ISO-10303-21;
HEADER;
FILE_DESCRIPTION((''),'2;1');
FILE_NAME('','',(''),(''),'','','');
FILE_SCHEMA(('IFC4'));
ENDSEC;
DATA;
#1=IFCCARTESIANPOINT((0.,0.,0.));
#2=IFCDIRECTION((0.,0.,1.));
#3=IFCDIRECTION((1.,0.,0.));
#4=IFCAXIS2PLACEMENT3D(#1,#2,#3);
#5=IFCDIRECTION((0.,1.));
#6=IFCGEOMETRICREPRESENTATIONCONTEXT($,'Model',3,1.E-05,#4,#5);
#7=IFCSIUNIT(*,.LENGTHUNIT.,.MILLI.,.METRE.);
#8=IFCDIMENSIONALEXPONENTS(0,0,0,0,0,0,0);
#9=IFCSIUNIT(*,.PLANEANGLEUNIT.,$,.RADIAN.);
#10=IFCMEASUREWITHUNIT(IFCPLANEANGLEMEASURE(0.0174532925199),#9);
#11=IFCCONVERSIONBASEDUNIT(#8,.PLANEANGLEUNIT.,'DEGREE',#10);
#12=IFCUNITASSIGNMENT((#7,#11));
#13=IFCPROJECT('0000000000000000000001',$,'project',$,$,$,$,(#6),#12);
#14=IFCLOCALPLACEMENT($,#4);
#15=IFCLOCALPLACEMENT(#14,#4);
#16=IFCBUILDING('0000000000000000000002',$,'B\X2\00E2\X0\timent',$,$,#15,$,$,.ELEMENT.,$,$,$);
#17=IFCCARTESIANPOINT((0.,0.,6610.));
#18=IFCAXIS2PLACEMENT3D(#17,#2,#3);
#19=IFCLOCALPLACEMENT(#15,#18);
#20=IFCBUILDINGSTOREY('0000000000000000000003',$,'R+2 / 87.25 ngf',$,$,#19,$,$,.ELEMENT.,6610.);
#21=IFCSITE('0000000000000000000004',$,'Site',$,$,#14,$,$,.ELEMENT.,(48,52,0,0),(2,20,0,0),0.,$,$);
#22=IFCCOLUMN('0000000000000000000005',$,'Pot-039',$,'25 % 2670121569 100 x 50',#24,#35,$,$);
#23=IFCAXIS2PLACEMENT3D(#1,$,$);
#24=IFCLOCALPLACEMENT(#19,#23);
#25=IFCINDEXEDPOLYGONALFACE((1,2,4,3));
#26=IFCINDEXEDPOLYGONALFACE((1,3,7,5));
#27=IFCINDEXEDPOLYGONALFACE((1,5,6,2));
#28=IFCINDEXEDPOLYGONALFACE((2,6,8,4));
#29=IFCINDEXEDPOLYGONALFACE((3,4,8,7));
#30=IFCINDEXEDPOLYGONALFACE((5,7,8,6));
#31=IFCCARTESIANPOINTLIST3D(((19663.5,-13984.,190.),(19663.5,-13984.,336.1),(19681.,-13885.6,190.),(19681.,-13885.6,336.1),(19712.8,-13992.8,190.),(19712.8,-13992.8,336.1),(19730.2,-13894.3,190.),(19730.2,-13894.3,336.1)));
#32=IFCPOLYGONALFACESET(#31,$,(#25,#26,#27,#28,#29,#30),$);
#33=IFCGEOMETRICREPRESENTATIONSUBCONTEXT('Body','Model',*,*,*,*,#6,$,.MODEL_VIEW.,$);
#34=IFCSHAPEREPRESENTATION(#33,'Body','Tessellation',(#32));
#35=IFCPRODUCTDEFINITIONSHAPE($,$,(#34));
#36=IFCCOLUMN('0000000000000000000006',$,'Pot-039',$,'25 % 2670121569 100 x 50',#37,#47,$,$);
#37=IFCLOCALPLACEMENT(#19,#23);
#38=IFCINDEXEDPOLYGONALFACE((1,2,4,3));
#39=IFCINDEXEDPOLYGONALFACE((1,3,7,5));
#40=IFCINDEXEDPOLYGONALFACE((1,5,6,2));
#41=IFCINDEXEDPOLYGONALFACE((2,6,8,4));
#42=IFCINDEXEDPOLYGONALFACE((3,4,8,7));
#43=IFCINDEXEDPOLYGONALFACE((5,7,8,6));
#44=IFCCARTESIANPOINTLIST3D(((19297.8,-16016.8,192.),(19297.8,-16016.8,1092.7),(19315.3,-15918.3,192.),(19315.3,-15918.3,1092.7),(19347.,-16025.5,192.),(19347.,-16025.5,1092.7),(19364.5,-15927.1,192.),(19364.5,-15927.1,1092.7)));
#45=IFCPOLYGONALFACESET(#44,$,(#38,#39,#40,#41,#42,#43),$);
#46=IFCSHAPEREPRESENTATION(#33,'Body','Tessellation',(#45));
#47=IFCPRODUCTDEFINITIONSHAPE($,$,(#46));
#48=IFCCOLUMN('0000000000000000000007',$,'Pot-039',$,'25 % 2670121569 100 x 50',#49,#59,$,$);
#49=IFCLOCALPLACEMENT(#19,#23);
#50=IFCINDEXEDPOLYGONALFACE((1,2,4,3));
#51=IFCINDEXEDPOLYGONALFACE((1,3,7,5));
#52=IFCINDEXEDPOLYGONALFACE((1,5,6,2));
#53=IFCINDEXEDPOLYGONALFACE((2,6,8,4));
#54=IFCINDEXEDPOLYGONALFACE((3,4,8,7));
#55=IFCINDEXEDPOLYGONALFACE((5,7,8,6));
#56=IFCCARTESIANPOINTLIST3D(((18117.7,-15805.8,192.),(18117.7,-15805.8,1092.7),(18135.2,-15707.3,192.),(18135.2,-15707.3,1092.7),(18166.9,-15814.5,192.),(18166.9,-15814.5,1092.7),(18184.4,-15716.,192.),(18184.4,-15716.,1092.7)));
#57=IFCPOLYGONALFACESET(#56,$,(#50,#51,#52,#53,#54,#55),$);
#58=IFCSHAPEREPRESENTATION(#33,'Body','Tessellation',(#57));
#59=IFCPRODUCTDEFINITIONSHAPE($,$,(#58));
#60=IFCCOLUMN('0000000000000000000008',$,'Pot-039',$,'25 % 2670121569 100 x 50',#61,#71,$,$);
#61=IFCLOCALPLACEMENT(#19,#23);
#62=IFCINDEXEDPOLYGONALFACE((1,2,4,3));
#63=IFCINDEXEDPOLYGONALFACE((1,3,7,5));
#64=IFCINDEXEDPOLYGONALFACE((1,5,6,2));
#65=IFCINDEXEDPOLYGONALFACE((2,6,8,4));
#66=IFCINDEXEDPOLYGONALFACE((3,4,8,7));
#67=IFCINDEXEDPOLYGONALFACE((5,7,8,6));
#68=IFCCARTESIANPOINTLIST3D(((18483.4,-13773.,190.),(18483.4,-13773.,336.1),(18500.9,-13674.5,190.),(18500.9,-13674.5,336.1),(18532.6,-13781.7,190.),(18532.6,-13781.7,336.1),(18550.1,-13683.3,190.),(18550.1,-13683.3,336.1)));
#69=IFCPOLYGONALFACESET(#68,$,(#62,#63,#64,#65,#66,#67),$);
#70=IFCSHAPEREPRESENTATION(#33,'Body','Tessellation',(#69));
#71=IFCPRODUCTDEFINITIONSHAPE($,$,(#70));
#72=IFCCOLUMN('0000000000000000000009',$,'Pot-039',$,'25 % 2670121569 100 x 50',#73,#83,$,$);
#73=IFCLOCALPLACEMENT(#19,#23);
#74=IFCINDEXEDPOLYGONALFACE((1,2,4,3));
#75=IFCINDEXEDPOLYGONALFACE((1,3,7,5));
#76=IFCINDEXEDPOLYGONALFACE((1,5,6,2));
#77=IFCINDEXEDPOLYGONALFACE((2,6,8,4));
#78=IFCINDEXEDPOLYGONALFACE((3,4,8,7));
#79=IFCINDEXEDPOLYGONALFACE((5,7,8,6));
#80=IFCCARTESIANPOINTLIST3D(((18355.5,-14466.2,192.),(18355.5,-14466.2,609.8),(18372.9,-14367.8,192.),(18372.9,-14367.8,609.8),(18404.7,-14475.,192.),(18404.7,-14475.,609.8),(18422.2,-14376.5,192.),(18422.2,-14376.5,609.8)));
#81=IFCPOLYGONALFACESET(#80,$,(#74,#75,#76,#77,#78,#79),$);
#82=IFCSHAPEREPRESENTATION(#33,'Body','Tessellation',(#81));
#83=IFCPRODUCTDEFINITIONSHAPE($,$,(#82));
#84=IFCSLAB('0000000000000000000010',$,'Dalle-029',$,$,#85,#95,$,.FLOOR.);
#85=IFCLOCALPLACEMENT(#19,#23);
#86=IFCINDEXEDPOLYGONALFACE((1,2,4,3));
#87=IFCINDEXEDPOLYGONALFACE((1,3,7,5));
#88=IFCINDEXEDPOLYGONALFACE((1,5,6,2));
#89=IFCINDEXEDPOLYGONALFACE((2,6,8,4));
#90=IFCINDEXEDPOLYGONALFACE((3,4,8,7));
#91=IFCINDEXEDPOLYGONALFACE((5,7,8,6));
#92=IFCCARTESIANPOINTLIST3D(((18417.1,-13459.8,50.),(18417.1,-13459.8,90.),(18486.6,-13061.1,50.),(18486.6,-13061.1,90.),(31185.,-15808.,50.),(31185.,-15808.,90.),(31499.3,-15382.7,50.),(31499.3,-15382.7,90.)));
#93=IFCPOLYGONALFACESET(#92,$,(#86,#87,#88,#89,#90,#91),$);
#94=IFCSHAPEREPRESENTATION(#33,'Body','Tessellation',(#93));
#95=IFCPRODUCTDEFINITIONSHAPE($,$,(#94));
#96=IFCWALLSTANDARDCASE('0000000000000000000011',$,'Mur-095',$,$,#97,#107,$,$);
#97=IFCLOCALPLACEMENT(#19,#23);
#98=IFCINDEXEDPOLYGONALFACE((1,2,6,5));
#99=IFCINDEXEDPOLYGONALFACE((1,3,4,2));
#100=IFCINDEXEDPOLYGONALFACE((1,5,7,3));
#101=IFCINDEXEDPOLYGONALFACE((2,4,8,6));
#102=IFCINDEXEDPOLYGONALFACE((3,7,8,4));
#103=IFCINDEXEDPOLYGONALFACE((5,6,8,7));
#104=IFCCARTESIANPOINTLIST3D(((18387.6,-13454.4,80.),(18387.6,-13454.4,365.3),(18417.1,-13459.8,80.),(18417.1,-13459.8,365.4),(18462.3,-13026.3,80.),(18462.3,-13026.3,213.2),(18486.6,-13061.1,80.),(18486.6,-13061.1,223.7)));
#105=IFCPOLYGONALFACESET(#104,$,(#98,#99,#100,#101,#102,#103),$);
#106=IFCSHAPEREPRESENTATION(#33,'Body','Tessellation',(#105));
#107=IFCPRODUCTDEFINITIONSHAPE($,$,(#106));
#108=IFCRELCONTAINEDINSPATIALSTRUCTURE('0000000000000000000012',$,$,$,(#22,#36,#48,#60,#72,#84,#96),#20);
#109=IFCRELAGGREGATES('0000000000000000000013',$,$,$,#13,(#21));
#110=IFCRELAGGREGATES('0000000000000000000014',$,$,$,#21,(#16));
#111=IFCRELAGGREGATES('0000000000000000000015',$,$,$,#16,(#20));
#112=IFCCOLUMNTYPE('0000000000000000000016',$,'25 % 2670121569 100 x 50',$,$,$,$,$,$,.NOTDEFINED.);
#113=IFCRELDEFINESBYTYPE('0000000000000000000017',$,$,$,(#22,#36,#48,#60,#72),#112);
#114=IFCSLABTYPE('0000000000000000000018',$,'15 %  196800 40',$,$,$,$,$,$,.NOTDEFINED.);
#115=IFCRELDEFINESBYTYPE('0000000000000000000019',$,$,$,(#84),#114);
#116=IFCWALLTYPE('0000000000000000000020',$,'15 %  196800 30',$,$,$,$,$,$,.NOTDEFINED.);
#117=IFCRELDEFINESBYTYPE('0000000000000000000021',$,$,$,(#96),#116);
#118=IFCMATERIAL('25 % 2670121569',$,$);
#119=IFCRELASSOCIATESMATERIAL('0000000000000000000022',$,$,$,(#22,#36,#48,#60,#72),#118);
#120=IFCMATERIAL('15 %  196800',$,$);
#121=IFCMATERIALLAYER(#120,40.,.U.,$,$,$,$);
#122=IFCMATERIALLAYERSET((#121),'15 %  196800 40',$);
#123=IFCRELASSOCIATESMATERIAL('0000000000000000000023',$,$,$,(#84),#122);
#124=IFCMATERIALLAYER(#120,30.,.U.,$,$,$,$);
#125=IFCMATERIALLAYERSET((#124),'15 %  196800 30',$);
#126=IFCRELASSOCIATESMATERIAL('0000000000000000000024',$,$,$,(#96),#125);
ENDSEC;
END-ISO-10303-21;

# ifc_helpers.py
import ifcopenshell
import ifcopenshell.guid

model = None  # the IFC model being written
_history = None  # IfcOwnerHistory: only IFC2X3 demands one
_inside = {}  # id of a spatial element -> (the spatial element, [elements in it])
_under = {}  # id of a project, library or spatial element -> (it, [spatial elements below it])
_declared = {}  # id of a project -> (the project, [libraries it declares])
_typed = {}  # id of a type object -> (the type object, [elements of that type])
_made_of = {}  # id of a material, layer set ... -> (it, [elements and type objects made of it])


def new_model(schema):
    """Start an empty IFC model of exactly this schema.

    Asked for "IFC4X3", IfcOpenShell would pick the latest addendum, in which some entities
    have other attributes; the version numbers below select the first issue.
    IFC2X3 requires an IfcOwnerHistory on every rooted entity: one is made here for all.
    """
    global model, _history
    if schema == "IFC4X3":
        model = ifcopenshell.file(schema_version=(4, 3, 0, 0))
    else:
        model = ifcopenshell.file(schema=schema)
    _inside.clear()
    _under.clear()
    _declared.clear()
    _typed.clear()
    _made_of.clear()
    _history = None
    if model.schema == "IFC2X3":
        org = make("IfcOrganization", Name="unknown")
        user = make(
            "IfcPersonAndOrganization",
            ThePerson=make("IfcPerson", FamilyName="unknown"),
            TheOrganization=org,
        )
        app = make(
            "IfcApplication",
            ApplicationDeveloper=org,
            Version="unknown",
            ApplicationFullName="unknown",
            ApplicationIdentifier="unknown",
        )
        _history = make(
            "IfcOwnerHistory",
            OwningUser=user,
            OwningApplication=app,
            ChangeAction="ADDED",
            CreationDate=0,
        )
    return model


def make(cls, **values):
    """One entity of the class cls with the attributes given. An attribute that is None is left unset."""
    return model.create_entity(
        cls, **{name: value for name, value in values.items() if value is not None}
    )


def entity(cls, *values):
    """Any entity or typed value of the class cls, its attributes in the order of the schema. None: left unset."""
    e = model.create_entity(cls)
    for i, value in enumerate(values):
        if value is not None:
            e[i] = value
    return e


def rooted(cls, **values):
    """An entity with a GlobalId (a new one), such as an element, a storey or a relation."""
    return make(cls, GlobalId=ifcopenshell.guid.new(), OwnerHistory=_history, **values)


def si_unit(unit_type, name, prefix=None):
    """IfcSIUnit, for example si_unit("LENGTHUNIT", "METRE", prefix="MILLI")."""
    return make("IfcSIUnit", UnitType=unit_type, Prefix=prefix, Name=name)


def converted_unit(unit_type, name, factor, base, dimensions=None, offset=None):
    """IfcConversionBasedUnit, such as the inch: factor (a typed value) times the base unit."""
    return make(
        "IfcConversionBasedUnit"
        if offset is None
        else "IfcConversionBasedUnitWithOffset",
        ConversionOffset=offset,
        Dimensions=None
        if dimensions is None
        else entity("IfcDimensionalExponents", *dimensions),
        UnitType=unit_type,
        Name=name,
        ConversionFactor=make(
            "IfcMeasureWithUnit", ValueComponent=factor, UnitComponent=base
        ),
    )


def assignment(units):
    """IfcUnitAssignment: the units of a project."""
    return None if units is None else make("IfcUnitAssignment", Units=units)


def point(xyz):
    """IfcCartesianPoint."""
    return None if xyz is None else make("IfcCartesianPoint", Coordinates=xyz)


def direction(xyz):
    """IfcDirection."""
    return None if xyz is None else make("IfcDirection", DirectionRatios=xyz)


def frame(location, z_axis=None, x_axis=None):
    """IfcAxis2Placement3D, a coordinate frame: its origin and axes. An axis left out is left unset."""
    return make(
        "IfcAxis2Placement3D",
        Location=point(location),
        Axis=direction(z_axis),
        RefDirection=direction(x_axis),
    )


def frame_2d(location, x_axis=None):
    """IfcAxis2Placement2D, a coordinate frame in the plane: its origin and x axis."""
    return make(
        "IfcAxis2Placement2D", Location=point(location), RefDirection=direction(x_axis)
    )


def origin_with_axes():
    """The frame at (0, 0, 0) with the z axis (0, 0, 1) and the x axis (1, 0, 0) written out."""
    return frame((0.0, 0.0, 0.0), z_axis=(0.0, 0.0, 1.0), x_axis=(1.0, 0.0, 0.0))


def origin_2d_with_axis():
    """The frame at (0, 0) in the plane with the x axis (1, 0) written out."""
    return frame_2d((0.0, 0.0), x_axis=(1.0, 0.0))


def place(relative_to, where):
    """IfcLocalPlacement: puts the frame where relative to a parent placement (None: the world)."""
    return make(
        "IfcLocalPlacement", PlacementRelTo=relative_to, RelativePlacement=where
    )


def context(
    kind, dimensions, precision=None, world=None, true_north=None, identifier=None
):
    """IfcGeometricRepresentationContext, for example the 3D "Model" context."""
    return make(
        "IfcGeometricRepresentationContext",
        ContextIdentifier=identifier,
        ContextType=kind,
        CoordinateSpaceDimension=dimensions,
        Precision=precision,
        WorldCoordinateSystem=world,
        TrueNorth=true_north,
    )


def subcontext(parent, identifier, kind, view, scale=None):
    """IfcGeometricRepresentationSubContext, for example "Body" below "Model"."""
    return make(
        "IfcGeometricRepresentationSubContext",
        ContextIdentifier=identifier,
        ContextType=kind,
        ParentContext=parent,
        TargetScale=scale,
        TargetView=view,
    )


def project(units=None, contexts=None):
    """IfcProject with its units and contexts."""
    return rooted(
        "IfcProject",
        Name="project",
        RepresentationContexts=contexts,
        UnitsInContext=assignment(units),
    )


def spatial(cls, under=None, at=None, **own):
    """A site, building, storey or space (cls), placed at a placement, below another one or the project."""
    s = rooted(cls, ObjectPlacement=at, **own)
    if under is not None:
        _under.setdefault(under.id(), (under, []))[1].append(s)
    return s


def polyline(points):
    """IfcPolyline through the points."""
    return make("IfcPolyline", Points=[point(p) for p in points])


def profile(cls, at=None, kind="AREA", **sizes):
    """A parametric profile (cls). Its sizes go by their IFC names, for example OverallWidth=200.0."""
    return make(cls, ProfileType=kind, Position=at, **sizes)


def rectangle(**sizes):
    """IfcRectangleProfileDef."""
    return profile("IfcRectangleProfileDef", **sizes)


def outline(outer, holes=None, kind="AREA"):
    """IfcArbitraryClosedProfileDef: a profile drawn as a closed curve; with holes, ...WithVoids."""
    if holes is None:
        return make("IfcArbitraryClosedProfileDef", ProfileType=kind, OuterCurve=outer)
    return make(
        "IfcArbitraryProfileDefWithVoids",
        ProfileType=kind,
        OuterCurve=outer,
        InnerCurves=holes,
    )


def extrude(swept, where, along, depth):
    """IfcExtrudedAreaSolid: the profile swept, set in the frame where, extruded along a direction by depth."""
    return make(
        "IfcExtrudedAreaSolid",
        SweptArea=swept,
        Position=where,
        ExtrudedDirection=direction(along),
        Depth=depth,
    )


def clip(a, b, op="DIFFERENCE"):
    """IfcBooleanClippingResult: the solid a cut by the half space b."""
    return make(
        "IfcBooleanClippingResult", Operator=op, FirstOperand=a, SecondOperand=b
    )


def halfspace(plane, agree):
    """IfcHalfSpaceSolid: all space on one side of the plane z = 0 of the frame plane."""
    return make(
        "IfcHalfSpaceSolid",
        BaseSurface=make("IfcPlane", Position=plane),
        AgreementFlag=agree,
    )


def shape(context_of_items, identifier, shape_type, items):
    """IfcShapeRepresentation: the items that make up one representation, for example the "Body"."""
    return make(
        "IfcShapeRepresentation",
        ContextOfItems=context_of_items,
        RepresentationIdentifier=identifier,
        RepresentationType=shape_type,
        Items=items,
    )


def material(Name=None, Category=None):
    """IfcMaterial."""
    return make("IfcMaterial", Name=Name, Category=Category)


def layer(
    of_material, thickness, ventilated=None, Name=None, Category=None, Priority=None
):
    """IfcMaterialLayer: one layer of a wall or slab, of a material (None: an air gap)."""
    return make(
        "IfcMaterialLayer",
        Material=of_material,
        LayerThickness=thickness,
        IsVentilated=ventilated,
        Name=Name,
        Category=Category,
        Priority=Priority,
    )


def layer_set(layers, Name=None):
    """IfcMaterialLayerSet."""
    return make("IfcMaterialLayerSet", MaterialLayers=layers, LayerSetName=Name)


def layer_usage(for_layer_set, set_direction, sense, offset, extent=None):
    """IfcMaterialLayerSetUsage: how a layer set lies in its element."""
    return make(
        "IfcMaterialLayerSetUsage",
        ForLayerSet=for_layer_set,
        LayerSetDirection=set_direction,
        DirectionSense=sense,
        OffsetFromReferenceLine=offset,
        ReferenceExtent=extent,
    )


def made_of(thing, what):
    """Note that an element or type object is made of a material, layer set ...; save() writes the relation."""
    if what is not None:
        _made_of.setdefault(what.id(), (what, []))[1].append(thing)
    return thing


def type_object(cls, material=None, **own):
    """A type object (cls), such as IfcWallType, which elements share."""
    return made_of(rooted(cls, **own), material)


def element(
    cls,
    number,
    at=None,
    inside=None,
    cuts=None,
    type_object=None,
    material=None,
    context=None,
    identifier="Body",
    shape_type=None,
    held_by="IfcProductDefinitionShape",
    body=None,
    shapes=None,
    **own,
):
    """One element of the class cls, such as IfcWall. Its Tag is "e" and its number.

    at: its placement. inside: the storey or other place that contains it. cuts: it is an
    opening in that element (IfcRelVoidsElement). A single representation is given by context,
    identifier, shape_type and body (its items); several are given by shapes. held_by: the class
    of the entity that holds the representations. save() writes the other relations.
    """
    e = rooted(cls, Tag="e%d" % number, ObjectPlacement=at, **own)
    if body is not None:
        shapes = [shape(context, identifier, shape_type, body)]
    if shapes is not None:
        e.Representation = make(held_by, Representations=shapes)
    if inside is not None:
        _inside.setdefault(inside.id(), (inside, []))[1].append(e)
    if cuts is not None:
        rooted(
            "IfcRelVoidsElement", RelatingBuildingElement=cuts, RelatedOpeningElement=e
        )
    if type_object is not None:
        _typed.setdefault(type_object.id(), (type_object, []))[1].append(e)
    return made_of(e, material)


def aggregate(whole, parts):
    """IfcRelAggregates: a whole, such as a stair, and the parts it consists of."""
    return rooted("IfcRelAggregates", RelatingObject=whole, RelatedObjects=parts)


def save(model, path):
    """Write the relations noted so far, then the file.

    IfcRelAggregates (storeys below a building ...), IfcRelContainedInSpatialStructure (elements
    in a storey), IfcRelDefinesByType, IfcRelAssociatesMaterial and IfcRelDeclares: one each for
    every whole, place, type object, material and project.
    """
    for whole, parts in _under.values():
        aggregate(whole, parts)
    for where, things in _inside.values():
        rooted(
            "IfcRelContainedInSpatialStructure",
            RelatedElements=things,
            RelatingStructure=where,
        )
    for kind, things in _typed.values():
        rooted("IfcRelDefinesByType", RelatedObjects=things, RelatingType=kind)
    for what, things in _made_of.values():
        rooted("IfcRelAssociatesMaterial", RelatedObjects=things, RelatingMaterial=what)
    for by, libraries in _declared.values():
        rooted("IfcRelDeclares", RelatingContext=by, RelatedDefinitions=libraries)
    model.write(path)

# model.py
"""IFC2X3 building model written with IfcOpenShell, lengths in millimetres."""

from ifc_helpers import new_model, entity, si_unit, converted_unit, direction, frame, origin_with_axes, origin_2d_with_axis, place, context, subcontext, project, spatial, polyline, rectangle, outline, extrude, clip, halfspace, material, layer, layer_set, layer_usage, type_object, element, save


model = new_model("IFC2X3")

# Units and contexts
model_context = context("Model", 3, precision=1e-05, world=origin_with_axes(), true_north=direction((0.0, 1.0)))
body_context = subcontext(model_context, "Body", "Model", "MODEL_VIEW")
ifc_project = project(units=[si_unit("LENGTHUNIT", "METRE", prefix="MILLI"), converted_unit("PLANEANGLEUNIT", "DEGREE", entity("IfcPlaneAngleMeasure", 0.0174532925199), si_unit("PLANEANGLEUNIT", "RADIAN"), dimensions=[0, 0, 0, 0, 0, 0, 0])], contexts=[model_context])

# Site, building, storey
site_placement = place(None, origin_with_axes())
site = spatial("IfcSite", under=ifc_project, at=site_placement, Name="Site", CompositionType="ELEMENT", RefLatitude=(48, 52, 0, 0), RefLongitude=(2, 20, 0, 0), RefElevation=0.0)
building_placement = place(site_placement, origin_with_axes())
building = spatial("IfcBuilding", under=site, at=building_placement, Name="Bâtiment", CompositionType="ELEMENT")
storey_placement = place(building_placement, frame((0.0, 0.0, 6610.0), z_axis=(0.0, 0.0, 1.0), x_axis=(1.0, 0.0, 0.0)))
storey = spatial("IfcBuildingStorey", under=building, at=storey_placement, Name="R+2 / 87.25 ngf", CompositionType="ELEMENT", Elevation=6610.0)

# Columns
ifc_material_1 = material(Name="25 % 2670121569")
column_type = type_object("IfcColumnType", Name="25 % 2670121569 100 x 50", PredefinedType="NOTDEFINED")
column_1_placement = place(storey_placement, frame((19696.9, -13939.2, 190.0), z_axis=(0.0, 0.0, 1.0), x_axis=(0.174407, 0.984674, 0.0)))
element("IfcColumn", 1, at=column_1_placement, inside=storey, type_object=column_type, material=ifc_material_1, Name="Pot-039", ObjectType="25 % 2670121569 100 x 50", context=body_context, shape_type="SweptSolid", body=[
    extrude(rectangle(XDim=100.0, YDim=50.0, at=origin_2d_with_axis()), origin_with_axes(), (0.0, 0.0, 1.0), 146.1),
])
for number, where, z_axis, x_axis, name in (
    (2, (19331.2, -15971.9, 192.0), (0.0, 0.0, 1.0), (0.17478, 0.984607, 0.0), "Pot-039"),
    (3, (18151.1, -15760.9, 192.0), (0.0, 0.0, 1.0), (0.17478, 0.984607, 0.0), "Pot-039"),
):
    element("IfcColumn", number, at=place(storey_placement, frame(where, z_axis=z_axis, x_axis=x_axis)), inside=storey, type_object=column_type, material=ifc_material_1, Name=name, ObjectType="25 % 2670121569 100 x 50", context=body_context, shape_type="SweptSolid", body=[
        extrude(rectangle(XDim=100.0, YDim=50.0, at=origin_2d_with_axis()), origin_with_axes(), (0.0, 0.0, 1.0), 900.7),
    ])
column_2_placement = place(storey_placement, frame((18516.7, -13728.1, 190.0), z_axis=(0.0, 0.0, 1.0), x_axis=(0.174407, 0.984674, 0.0)))
element("IfcColumn", 4, at=column_2_placement, inside=storey, type_object=column_type, material=ifc_material_1, Name="Pot-039", ObjectType="25 % 2670121569 100 x 50", context=body_context, shape_type="SweptSolid", body=[
    extrude(rectangle(XDim=100.0, YDim=50.0, at=origin_2d_with_axis()), origin_with_axes(), (0.0, 0.0, 1.0), 146.1),
])
column_3_placement = place(storey_placement, frame((18388.8, -14421.4, 192.0), z_axis=(0.0, 0.0, 1.0), x_axis=(0.17478, 0.984607, 0.0)))
element("IfcColumn", 5, at=column_3_placement, inside=storey, type_object=column_type, material=ifc_material_1, Name="Pot-039", ObjectType="25 % 2670121569 100 x 50", context=body_context, shape_type="SweptSolid", body=[
    extrude(rectangle(XDim=100.0, YDim=50.0, at=origin_2d_with_axis()), origin_with_axes(), (0.0, 0.0, 1.0), 417.8),
])

# Slab
ifc_material_2 = material(Name="15 %  196800")
ifc_layer_1 = layer(ifc_material_2, 40.0, ventilated="UNKNOWN")
ifc_layer_set_1 = layer_set([ifc_layer_1], Name="15 %  196800 40")
ifc_layer_usage_1 = layer_usage(ifc_layer_set_1, "AXIS3", "NEGATIVE", 40.0)
slab_type = type_object("IfcSlabType", Name="15 %  196800 40", PredefinedType="NOTDEFINED")
slab_placement = place(storey_placement, frame((18486.6, -13061.1, 90.0), z_axis=(0.0, 0.0, 1.0), x_axis=(1.0, 0.0, 0.0)))
element("IfcSlab", 6, at=slab_placement, inside=storey, type_object=slab_type, material=ifc_layer_usage_1, Name="Dalle-029", PredefinedType="FLOOR", context=body_context, shape_type="SweptSolid", body=[
    extrude(outline(polyline([(0.0, 0.0), (-69.6, -398.6), (12698.4, -2746.8), (13012.7, -2321.5), (0.0, 0.0)])), frame((0.0, 0.0, -40.0), z_axis=(0.0, 0.0, 1.0), x_axis=(1.0, 0.0, 0.0)), (0.0, 0.0, 1.0), 40.0),
])

# Wall
ifc_layer_2 = layer(ifc_material_2, 30.0, ventilated="UNKNOWN")
ifc_layer_set_2 = layer_set([ifc_layer_2], Name="15 %  196800 30")
ifc_layer_usage_2 = layer_usage(ifc_layer_set_2, "AXIS2", "NEGATIVE", 30.0)
wall_type = type_object("IfcWallType", Name="15 %  196800 30", PredefinedType="NOTDEFINED")
wall_placement = place(storey_placement, frame((18462.3, -13026.3, 80.0), z_axis=(0.0, 0.0, 1.0), x_axis=(-0.171879, -0.985118, 0.0)))
element("IfcWallStandardCase", 7, at=wall_placement, inside=storey, type_object=wall_type, material=ifc_layer_usage_2, Name="Mur-095", context=body_context, shape_type="Clipping", body=[
    clip(extrude(outline(polyline([(0.0, 0.0), (434.5, 0.0), (434.8, 30.0), (30.1, 30.0), (0.0, 0.0)])), origin_with_axes(), (0.0, 0.0, 1.0), 590.0), halfspace(frame((-41.5, 0.1, 118.7), z_axis=(0.33035, -0.000576, -0.943858), x_axis=(0.0, 1.0, -0.00061)), True)),
])

save(model, "model.ifc")
